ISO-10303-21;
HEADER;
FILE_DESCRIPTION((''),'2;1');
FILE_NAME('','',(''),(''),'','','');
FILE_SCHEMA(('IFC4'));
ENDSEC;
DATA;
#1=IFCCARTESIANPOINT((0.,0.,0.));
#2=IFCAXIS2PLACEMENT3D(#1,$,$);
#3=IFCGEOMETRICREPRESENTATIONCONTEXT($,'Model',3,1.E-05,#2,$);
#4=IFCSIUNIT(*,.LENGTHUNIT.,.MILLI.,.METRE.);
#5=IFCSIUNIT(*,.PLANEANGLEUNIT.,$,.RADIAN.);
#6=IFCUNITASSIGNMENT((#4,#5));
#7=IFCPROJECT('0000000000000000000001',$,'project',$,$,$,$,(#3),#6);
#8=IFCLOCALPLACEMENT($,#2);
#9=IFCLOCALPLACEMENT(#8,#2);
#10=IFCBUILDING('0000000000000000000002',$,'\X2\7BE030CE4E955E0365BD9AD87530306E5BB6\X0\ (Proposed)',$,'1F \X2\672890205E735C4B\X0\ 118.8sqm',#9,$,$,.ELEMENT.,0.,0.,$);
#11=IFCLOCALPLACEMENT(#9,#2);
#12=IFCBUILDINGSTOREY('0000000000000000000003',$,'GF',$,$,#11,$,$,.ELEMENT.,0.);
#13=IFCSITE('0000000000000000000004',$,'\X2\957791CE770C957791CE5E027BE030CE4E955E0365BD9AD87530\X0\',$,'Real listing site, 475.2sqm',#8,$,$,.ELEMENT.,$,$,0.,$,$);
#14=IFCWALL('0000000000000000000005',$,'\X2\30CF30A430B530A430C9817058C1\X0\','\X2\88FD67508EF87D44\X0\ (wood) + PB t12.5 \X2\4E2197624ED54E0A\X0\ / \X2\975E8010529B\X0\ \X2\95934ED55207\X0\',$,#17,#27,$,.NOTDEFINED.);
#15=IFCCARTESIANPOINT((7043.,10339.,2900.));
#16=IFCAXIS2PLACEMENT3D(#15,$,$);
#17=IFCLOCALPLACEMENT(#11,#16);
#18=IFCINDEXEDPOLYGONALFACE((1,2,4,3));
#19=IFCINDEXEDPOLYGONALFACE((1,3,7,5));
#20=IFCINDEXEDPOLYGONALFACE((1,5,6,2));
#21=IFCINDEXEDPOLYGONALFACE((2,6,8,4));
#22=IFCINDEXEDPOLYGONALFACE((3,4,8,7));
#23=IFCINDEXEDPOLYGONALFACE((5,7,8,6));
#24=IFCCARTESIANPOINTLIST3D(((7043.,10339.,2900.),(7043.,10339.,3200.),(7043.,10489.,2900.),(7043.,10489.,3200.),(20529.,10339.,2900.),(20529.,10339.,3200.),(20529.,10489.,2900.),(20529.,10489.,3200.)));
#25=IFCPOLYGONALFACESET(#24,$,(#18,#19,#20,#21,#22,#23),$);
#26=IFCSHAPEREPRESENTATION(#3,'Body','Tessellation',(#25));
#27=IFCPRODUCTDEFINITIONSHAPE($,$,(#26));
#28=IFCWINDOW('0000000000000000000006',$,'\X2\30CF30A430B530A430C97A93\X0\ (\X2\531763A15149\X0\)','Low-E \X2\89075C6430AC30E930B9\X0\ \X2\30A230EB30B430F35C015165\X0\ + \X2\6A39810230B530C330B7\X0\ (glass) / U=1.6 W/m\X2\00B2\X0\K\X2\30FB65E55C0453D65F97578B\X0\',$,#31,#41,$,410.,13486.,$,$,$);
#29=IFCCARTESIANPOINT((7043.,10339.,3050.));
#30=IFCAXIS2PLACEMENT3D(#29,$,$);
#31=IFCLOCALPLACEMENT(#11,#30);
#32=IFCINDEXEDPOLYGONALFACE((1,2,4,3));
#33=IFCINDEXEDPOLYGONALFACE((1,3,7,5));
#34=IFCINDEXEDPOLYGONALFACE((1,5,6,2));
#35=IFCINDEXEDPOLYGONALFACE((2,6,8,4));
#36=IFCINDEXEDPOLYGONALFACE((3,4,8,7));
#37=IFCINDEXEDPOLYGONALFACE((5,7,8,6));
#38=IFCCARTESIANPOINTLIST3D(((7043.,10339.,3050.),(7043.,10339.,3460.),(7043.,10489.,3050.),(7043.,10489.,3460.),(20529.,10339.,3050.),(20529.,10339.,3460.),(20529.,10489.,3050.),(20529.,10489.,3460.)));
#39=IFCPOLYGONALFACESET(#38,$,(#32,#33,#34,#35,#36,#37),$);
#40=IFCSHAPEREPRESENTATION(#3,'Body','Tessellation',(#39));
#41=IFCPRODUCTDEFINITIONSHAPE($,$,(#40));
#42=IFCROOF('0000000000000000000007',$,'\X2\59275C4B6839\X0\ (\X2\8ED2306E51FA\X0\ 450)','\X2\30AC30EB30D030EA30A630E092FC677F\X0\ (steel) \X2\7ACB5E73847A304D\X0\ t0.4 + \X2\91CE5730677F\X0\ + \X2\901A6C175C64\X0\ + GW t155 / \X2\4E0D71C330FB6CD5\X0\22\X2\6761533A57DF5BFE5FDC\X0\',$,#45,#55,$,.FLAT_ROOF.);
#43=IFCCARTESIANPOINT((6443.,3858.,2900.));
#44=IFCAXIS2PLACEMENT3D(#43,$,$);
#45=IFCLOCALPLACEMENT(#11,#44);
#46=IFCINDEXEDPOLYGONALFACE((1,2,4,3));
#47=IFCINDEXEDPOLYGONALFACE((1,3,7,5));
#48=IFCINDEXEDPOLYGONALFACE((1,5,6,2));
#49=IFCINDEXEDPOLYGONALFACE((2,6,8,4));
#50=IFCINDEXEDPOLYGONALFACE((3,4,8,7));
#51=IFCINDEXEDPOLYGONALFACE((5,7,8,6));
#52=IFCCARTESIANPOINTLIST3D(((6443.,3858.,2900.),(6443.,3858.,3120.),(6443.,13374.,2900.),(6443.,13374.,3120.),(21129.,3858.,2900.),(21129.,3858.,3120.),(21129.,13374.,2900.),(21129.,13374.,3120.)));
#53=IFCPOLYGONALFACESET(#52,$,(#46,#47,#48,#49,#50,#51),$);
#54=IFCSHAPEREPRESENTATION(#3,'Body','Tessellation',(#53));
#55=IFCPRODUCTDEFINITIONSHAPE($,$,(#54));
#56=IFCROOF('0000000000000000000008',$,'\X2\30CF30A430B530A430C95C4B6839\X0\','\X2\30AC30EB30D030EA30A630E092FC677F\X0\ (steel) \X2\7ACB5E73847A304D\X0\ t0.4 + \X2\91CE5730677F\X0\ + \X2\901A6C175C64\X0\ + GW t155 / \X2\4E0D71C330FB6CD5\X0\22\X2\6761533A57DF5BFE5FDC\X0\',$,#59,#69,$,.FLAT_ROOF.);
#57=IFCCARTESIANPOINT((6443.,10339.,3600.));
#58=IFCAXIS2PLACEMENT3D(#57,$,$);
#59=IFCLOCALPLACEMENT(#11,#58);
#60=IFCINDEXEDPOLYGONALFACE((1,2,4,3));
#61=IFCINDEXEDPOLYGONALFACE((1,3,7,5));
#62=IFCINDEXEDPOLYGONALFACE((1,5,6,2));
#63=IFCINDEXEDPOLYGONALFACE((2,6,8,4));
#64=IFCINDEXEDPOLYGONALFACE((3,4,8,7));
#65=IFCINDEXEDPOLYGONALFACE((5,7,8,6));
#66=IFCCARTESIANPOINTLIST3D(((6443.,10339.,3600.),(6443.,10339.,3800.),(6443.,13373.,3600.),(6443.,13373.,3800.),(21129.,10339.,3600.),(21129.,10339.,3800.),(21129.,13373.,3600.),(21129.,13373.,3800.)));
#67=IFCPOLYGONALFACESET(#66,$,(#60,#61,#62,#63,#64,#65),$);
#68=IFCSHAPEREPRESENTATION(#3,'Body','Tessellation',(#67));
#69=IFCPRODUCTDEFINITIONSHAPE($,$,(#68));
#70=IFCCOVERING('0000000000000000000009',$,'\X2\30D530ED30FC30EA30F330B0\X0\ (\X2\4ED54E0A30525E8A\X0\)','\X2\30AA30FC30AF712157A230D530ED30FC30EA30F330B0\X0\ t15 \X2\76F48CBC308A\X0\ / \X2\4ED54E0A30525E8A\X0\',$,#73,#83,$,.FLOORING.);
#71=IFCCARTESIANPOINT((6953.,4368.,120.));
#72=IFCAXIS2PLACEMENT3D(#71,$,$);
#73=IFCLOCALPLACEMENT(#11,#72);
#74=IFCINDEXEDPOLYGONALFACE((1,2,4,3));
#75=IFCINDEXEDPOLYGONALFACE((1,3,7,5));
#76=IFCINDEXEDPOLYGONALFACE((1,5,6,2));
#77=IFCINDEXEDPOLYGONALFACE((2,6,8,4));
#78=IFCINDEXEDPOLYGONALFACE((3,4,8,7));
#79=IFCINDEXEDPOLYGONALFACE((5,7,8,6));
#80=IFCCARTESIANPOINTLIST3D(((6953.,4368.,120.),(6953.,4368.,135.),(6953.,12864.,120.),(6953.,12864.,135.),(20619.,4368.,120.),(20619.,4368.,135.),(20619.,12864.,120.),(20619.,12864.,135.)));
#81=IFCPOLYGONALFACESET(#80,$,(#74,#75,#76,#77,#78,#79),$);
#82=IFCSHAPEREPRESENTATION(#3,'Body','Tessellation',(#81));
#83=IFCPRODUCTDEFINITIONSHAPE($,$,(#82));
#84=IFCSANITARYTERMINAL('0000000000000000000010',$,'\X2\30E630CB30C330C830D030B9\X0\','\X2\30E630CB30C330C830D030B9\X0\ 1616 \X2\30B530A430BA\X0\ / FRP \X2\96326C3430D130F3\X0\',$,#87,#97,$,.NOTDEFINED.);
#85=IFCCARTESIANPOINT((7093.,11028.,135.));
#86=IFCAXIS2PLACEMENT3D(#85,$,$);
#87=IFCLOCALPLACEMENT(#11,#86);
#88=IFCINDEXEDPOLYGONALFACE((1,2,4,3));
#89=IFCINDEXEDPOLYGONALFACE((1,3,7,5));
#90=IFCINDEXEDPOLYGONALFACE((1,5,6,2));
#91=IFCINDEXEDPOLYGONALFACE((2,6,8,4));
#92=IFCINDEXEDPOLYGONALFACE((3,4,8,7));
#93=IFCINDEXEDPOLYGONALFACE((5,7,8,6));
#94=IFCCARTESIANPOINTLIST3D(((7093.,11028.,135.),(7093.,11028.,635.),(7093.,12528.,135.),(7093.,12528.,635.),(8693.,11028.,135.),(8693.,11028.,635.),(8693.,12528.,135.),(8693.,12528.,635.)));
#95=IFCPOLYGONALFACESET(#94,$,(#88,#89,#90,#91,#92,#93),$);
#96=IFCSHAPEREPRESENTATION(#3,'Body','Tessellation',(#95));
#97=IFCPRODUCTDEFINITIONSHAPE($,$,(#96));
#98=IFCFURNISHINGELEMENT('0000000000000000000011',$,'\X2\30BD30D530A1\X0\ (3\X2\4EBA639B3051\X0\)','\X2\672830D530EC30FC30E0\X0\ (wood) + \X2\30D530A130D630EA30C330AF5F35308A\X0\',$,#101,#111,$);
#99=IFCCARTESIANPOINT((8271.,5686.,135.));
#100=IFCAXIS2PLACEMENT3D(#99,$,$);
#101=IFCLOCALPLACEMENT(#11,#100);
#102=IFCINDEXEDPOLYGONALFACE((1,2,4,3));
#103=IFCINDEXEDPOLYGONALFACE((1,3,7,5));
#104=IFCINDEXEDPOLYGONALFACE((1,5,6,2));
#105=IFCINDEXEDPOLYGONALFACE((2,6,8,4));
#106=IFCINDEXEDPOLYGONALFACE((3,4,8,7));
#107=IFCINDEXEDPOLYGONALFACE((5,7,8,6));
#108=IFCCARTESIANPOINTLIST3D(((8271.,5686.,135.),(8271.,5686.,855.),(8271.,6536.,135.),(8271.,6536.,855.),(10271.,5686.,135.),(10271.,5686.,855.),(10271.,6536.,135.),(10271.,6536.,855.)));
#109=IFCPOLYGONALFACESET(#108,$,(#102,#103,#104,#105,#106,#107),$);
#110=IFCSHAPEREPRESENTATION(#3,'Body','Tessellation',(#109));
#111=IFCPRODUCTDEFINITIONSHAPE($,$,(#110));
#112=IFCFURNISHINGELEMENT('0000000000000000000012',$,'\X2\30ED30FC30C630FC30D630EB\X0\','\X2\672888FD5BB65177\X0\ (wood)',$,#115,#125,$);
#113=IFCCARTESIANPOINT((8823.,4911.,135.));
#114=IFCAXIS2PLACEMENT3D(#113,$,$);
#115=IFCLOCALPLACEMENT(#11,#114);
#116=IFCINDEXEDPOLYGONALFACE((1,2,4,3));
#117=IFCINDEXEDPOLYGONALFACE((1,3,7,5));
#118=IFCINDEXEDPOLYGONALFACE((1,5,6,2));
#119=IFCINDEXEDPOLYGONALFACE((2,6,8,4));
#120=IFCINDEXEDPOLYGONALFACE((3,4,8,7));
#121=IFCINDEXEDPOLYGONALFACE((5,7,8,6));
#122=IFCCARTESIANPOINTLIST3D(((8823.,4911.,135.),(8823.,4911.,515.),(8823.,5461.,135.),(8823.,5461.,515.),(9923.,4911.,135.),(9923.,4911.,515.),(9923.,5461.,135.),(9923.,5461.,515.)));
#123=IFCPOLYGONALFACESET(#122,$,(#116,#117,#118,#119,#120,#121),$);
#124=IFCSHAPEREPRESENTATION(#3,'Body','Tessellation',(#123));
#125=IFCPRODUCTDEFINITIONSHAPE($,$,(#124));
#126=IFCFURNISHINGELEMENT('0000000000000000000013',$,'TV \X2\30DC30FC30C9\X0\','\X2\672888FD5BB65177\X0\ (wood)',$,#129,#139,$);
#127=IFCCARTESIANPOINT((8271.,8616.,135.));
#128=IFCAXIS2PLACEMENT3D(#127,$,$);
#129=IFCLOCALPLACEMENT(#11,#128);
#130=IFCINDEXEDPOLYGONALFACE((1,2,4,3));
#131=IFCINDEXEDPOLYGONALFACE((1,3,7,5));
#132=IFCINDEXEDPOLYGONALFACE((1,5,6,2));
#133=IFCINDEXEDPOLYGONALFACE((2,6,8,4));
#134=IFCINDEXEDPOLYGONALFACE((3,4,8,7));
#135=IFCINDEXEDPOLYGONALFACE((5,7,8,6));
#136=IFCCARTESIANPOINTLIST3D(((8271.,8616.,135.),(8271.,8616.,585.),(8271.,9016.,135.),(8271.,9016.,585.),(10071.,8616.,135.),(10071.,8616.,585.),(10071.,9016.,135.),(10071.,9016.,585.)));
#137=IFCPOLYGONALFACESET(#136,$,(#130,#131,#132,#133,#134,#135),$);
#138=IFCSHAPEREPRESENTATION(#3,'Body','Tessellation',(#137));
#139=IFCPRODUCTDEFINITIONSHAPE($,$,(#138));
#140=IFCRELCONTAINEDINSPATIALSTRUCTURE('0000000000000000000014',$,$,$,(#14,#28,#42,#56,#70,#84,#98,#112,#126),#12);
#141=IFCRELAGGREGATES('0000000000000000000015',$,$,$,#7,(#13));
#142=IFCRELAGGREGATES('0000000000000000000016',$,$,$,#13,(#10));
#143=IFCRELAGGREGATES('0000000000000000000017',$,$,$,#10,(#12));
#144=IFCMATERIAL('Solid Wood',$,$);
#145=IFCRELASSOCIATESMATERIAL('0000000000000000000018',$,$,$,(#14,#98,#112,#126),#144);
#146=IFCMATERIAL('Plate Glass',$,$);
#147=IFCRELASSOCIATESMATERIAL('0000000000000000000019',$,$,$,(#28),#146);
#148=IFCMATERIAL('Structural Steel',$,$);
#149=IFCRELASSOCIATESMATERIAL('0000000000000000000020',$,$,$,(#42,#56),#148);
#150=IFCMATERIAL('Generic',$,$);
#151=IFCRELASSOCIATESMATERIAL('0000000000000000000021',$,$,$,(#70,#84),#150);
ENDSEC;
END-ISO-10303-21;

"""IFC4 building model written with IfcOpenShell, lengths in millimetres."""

from ifc_helpers import new_model, si_unit, frame, frame_2d, origin, place, context, project, spatial, rectangle, extrude, material, element, fill, save


model = new_model("IFC4")

# Units and contexts
model_context = context("Model", 3, precision=1e-05, world=origin())
ifc_project = project(units=[si_unit("LENGTHUNIT", "METRE", prefix="MILLI"), si_unit("PLANEANGLEUNIT", "RADIAN")], contexts=[model_context])

# Site, building, storey
site_placement = place(None, origin())
site = spatial("IfcSite", under=ifc_project, at=site_placement, Name="長野県長野市篠ノ井布施高田", ObjectType="Real listing site, 475.2sqm", CompositionType="ELEMENT", RefElevation=0.0)
building_placement = place(site_placement, origin())
building = spatial("IfcBuilding", under=site, at=building_placement, Name="篠ノ井布施高田の家 (Proposed)", ObjectType="1F 木造平屋 118.8sqm", CompositionType="ELEMENT", ElevationOfRefHeight=0.0, ElevationOfTerrain=0.0)
storey_placement = place(building_placement, origin())
storey = spatial("IfcBuildingStorey", under=building, at=storey_placement, Name="GF", CompositionType="ELEMENT", Elevation=0.0)

# Shared definitions
ifc_material_1 = material(Name="Solid Wood")

# Shared definitions
ifc_material_2 = material(Name="Plate Glass")

# Wall, opening, window
wall_1_placement = place(storey_placement, frame((7043.0, 10339.0, 2900.0)))
wall_1 = element("IfcWall", 1, at=wall_1_placement, inside=storey, material=ifc_material_1, Name="ハイサイド腰壁", Description="製材軸組 (wood) + PB t12.5 両面仕上 / 非耐力 間仕切", PredefinedType="NOTDEFINED", context=model_context, shape_type="SweptSolid", body=[
    extrude(rectangle(XDim=13486.0, YDim=150.0, at=frame_2d((6743.0, 75.0))), frame((7043.0, 10339.0, 2900.0)), (0.0, 0.0, 1.0), 700.0),
])
opening_1_placement = place(storey_placement, frame((7043.0, 10339.0, 3050.0)))
opening_1 = element("IfcOpeningElement", 2, at=opening_1_placement, cuts=wall_1, PredefinedType="NOTDEFINED", context=model_context, shape_type="SweptSolid", body=[
    extrude(rectangle(XDim=13486.0, YDim=150.0, at=frame_2d((6743.0, 75.0))), frame((7043.0, 10339.0, 3050.0)), (0.0, 0.0, 1.0), 410.0),
])
window_1_placement = place(storey_placement, frame((7043.0, 10339.0, 3050.0)))
window_1 = element("IfcWindow", 3, at=window_1_placement, inside=storey, material=ifc_material_2, Name="ハイサイド窓 (北採光)", Description="Low-E 複層ガラス アルゴン封入 + 樹脂サッシ (glass) / U=1.6 W/m²K・日射取得型", OverallHeight=410.0, OverallWidth=13486.0, context=model_context, shape_type="SweptSolid", body=[
    extrude(rectangle(XDim=13486.0, YDim=150.0, at=frame_2d((6743.0, 75.0))), frame((7043.0, 10339.0, 3050.0)), (0.0, 0.0, 1.0), 410.0),
])
fill(opening_1, window_1)

# Roofs
ifc_material_3 = material(Name="Structural Steel")
roof_1_placement = place(storey_placement, frame((6443.0, 3858.0, 2900.0)))
element("IfcRoof", 4, at=roof_1_placement, inside=storey, material=ifc_material_3, Name="大屋根 (軒の出 450)", Description="ガルバリウム鋼板 (steel) 立平葺き t0.4 + 野地板 + 通気層 + GW t155 / 不燃・法22条区域対応", PredefinedType="FLAT_ROOF", context=model_context, shape_type="SweptSolid", body=[
    extrude(rectangle(XDim=14686.0, YDim=9516.0, at=frame_2d((7343.0, 4758.0))), frame((6443.0, 3858.0, 2900.0)), (0.0, 0.0, 1.0), 220.0),
])
roof_2_placement = place(storey_placement, frame((6443.0, 10339.0, 3600.0)))
element("IfcRoof", 5, at=roof_2_placement, inside=storey, material=ifc_material_3, Name="ハイサイド屋根", Description="ガルバリウム鋼板 (steel) 立平葺き t0.4 + 野地板 + 通気層 + GW t155 / 不燃・法22条区域対応", PredefinedType="FLAT_ROOF", context=model_context, shape_type="SweptSolid", body=[
    extrude(rectangle(XDim=14686.0, YDim=3034.0, at=frame_2d((7343.0, 1517.0))), frame((6443.0, 10339.0, 3600.0)), (0.0, 0.0, 1.0), 200.0),
])

# Covering
ifc_material_4 = material(Name="Generic")
covering_placement = place(storey_placement, frame((6953.0, 4368.0, 120.0)))
element("IfcCovering", 6, at=covering_placement, inside=storey, material=ifc_material_4, Name="フローリング (仕上げ床)", Description="オーク無垢フローリング t15 直貼り / 仕上げ床", PredefinedType="FLOORING", context=model_context, shape_type="SweptSolid", body=[
    extrude(rectangle(XDim=13666.0, YDim=8496.0, at=frame_2d((6833.0, 4248.0))), frame((6953.0, 4368.0, 120.0)), (0.0, 0.0, 1.0), 15.0),
])

# Sanitary terminal
sanitary_terminal_placement = place(storey_placement, frame((7093.0, 11028.0, 135.0)))
element("IfcSanitaryTerminal", 7, at=sanitary_terminal_placement, inside=storey, material=ifc_material_4, Name="ユニットバス", Description="ユニットバス 1616 サイズ / FRP 防水パン", PredefinedType="NOTDEFINED", context=model_context, shape_type="SweptSolid", body=[
    extrude(rectangle(XDim=1600.0, YDim=1500.0, at=frame_2d((800.0, 750.0))), frame((7093.0, 11028.0, 135.0)), (0.0, 0.0, 1.0), 500.0),
])

# Furnishing elements
furnishing_1_placement = place(storey_placement, frame((8271.0, 5686.0, 135.0)))
element("IfcFurnishingElement", 8, at=furnishing_1_placement, inside=storey, material=ifc_material_1, Name="ソファ (3人掛け)", Description="木フレーム (wood) + ファブリック張り", context=model_context, shape_type="SweptSolid", body=[
    extrude(rectangle(XDim=2000.0, YDim=850.0, at=frame_2d((1000.0, 425.0))), frame((8271.0, 5686.0, 135.0)), (0.0, 0.0, 1.0), 720.0),
])
furnishing_2_placement = place(storey_placement, frame((8823.0, 4911.0, 135.0)))
element("IfcFurnishingElement", 9, at=furnishing_2_placement, inside=storey, material=ifc_material_1, Name="ローテーブル", Description="木製家具 (wood)", context=model_context, shape_type="SweptSolid", body=[
    extrude(rectangle(XDim=1100.0, YDim=550.0, at=frame_2d((550.0, 275.0))), frame((8823.0, 4911.0, 135.0)), (0.0, 0.0, 1.0), 380.0),
])
furnishing_3_placement = place(storey_placement, frame((8271.0, 8616.0, 135.0)))
element("IfcFurnishingElement", 10, at=furnishing_3_placement, inside=storey, material=ifc_material_1, Name="TV ボード", Description="木製家具 (wood)", context=model_context, shape_type="SweptSolid", body=[
    extrude(rectangle(XDim=1800.0, YDim=400.0, at=frame_2d((900.0, 200.0))), frame((8271.0, 8616.0, 135.0)), (0.0, 0.0, 1.0), 450.0),
])

save(model, "model.ifc")
